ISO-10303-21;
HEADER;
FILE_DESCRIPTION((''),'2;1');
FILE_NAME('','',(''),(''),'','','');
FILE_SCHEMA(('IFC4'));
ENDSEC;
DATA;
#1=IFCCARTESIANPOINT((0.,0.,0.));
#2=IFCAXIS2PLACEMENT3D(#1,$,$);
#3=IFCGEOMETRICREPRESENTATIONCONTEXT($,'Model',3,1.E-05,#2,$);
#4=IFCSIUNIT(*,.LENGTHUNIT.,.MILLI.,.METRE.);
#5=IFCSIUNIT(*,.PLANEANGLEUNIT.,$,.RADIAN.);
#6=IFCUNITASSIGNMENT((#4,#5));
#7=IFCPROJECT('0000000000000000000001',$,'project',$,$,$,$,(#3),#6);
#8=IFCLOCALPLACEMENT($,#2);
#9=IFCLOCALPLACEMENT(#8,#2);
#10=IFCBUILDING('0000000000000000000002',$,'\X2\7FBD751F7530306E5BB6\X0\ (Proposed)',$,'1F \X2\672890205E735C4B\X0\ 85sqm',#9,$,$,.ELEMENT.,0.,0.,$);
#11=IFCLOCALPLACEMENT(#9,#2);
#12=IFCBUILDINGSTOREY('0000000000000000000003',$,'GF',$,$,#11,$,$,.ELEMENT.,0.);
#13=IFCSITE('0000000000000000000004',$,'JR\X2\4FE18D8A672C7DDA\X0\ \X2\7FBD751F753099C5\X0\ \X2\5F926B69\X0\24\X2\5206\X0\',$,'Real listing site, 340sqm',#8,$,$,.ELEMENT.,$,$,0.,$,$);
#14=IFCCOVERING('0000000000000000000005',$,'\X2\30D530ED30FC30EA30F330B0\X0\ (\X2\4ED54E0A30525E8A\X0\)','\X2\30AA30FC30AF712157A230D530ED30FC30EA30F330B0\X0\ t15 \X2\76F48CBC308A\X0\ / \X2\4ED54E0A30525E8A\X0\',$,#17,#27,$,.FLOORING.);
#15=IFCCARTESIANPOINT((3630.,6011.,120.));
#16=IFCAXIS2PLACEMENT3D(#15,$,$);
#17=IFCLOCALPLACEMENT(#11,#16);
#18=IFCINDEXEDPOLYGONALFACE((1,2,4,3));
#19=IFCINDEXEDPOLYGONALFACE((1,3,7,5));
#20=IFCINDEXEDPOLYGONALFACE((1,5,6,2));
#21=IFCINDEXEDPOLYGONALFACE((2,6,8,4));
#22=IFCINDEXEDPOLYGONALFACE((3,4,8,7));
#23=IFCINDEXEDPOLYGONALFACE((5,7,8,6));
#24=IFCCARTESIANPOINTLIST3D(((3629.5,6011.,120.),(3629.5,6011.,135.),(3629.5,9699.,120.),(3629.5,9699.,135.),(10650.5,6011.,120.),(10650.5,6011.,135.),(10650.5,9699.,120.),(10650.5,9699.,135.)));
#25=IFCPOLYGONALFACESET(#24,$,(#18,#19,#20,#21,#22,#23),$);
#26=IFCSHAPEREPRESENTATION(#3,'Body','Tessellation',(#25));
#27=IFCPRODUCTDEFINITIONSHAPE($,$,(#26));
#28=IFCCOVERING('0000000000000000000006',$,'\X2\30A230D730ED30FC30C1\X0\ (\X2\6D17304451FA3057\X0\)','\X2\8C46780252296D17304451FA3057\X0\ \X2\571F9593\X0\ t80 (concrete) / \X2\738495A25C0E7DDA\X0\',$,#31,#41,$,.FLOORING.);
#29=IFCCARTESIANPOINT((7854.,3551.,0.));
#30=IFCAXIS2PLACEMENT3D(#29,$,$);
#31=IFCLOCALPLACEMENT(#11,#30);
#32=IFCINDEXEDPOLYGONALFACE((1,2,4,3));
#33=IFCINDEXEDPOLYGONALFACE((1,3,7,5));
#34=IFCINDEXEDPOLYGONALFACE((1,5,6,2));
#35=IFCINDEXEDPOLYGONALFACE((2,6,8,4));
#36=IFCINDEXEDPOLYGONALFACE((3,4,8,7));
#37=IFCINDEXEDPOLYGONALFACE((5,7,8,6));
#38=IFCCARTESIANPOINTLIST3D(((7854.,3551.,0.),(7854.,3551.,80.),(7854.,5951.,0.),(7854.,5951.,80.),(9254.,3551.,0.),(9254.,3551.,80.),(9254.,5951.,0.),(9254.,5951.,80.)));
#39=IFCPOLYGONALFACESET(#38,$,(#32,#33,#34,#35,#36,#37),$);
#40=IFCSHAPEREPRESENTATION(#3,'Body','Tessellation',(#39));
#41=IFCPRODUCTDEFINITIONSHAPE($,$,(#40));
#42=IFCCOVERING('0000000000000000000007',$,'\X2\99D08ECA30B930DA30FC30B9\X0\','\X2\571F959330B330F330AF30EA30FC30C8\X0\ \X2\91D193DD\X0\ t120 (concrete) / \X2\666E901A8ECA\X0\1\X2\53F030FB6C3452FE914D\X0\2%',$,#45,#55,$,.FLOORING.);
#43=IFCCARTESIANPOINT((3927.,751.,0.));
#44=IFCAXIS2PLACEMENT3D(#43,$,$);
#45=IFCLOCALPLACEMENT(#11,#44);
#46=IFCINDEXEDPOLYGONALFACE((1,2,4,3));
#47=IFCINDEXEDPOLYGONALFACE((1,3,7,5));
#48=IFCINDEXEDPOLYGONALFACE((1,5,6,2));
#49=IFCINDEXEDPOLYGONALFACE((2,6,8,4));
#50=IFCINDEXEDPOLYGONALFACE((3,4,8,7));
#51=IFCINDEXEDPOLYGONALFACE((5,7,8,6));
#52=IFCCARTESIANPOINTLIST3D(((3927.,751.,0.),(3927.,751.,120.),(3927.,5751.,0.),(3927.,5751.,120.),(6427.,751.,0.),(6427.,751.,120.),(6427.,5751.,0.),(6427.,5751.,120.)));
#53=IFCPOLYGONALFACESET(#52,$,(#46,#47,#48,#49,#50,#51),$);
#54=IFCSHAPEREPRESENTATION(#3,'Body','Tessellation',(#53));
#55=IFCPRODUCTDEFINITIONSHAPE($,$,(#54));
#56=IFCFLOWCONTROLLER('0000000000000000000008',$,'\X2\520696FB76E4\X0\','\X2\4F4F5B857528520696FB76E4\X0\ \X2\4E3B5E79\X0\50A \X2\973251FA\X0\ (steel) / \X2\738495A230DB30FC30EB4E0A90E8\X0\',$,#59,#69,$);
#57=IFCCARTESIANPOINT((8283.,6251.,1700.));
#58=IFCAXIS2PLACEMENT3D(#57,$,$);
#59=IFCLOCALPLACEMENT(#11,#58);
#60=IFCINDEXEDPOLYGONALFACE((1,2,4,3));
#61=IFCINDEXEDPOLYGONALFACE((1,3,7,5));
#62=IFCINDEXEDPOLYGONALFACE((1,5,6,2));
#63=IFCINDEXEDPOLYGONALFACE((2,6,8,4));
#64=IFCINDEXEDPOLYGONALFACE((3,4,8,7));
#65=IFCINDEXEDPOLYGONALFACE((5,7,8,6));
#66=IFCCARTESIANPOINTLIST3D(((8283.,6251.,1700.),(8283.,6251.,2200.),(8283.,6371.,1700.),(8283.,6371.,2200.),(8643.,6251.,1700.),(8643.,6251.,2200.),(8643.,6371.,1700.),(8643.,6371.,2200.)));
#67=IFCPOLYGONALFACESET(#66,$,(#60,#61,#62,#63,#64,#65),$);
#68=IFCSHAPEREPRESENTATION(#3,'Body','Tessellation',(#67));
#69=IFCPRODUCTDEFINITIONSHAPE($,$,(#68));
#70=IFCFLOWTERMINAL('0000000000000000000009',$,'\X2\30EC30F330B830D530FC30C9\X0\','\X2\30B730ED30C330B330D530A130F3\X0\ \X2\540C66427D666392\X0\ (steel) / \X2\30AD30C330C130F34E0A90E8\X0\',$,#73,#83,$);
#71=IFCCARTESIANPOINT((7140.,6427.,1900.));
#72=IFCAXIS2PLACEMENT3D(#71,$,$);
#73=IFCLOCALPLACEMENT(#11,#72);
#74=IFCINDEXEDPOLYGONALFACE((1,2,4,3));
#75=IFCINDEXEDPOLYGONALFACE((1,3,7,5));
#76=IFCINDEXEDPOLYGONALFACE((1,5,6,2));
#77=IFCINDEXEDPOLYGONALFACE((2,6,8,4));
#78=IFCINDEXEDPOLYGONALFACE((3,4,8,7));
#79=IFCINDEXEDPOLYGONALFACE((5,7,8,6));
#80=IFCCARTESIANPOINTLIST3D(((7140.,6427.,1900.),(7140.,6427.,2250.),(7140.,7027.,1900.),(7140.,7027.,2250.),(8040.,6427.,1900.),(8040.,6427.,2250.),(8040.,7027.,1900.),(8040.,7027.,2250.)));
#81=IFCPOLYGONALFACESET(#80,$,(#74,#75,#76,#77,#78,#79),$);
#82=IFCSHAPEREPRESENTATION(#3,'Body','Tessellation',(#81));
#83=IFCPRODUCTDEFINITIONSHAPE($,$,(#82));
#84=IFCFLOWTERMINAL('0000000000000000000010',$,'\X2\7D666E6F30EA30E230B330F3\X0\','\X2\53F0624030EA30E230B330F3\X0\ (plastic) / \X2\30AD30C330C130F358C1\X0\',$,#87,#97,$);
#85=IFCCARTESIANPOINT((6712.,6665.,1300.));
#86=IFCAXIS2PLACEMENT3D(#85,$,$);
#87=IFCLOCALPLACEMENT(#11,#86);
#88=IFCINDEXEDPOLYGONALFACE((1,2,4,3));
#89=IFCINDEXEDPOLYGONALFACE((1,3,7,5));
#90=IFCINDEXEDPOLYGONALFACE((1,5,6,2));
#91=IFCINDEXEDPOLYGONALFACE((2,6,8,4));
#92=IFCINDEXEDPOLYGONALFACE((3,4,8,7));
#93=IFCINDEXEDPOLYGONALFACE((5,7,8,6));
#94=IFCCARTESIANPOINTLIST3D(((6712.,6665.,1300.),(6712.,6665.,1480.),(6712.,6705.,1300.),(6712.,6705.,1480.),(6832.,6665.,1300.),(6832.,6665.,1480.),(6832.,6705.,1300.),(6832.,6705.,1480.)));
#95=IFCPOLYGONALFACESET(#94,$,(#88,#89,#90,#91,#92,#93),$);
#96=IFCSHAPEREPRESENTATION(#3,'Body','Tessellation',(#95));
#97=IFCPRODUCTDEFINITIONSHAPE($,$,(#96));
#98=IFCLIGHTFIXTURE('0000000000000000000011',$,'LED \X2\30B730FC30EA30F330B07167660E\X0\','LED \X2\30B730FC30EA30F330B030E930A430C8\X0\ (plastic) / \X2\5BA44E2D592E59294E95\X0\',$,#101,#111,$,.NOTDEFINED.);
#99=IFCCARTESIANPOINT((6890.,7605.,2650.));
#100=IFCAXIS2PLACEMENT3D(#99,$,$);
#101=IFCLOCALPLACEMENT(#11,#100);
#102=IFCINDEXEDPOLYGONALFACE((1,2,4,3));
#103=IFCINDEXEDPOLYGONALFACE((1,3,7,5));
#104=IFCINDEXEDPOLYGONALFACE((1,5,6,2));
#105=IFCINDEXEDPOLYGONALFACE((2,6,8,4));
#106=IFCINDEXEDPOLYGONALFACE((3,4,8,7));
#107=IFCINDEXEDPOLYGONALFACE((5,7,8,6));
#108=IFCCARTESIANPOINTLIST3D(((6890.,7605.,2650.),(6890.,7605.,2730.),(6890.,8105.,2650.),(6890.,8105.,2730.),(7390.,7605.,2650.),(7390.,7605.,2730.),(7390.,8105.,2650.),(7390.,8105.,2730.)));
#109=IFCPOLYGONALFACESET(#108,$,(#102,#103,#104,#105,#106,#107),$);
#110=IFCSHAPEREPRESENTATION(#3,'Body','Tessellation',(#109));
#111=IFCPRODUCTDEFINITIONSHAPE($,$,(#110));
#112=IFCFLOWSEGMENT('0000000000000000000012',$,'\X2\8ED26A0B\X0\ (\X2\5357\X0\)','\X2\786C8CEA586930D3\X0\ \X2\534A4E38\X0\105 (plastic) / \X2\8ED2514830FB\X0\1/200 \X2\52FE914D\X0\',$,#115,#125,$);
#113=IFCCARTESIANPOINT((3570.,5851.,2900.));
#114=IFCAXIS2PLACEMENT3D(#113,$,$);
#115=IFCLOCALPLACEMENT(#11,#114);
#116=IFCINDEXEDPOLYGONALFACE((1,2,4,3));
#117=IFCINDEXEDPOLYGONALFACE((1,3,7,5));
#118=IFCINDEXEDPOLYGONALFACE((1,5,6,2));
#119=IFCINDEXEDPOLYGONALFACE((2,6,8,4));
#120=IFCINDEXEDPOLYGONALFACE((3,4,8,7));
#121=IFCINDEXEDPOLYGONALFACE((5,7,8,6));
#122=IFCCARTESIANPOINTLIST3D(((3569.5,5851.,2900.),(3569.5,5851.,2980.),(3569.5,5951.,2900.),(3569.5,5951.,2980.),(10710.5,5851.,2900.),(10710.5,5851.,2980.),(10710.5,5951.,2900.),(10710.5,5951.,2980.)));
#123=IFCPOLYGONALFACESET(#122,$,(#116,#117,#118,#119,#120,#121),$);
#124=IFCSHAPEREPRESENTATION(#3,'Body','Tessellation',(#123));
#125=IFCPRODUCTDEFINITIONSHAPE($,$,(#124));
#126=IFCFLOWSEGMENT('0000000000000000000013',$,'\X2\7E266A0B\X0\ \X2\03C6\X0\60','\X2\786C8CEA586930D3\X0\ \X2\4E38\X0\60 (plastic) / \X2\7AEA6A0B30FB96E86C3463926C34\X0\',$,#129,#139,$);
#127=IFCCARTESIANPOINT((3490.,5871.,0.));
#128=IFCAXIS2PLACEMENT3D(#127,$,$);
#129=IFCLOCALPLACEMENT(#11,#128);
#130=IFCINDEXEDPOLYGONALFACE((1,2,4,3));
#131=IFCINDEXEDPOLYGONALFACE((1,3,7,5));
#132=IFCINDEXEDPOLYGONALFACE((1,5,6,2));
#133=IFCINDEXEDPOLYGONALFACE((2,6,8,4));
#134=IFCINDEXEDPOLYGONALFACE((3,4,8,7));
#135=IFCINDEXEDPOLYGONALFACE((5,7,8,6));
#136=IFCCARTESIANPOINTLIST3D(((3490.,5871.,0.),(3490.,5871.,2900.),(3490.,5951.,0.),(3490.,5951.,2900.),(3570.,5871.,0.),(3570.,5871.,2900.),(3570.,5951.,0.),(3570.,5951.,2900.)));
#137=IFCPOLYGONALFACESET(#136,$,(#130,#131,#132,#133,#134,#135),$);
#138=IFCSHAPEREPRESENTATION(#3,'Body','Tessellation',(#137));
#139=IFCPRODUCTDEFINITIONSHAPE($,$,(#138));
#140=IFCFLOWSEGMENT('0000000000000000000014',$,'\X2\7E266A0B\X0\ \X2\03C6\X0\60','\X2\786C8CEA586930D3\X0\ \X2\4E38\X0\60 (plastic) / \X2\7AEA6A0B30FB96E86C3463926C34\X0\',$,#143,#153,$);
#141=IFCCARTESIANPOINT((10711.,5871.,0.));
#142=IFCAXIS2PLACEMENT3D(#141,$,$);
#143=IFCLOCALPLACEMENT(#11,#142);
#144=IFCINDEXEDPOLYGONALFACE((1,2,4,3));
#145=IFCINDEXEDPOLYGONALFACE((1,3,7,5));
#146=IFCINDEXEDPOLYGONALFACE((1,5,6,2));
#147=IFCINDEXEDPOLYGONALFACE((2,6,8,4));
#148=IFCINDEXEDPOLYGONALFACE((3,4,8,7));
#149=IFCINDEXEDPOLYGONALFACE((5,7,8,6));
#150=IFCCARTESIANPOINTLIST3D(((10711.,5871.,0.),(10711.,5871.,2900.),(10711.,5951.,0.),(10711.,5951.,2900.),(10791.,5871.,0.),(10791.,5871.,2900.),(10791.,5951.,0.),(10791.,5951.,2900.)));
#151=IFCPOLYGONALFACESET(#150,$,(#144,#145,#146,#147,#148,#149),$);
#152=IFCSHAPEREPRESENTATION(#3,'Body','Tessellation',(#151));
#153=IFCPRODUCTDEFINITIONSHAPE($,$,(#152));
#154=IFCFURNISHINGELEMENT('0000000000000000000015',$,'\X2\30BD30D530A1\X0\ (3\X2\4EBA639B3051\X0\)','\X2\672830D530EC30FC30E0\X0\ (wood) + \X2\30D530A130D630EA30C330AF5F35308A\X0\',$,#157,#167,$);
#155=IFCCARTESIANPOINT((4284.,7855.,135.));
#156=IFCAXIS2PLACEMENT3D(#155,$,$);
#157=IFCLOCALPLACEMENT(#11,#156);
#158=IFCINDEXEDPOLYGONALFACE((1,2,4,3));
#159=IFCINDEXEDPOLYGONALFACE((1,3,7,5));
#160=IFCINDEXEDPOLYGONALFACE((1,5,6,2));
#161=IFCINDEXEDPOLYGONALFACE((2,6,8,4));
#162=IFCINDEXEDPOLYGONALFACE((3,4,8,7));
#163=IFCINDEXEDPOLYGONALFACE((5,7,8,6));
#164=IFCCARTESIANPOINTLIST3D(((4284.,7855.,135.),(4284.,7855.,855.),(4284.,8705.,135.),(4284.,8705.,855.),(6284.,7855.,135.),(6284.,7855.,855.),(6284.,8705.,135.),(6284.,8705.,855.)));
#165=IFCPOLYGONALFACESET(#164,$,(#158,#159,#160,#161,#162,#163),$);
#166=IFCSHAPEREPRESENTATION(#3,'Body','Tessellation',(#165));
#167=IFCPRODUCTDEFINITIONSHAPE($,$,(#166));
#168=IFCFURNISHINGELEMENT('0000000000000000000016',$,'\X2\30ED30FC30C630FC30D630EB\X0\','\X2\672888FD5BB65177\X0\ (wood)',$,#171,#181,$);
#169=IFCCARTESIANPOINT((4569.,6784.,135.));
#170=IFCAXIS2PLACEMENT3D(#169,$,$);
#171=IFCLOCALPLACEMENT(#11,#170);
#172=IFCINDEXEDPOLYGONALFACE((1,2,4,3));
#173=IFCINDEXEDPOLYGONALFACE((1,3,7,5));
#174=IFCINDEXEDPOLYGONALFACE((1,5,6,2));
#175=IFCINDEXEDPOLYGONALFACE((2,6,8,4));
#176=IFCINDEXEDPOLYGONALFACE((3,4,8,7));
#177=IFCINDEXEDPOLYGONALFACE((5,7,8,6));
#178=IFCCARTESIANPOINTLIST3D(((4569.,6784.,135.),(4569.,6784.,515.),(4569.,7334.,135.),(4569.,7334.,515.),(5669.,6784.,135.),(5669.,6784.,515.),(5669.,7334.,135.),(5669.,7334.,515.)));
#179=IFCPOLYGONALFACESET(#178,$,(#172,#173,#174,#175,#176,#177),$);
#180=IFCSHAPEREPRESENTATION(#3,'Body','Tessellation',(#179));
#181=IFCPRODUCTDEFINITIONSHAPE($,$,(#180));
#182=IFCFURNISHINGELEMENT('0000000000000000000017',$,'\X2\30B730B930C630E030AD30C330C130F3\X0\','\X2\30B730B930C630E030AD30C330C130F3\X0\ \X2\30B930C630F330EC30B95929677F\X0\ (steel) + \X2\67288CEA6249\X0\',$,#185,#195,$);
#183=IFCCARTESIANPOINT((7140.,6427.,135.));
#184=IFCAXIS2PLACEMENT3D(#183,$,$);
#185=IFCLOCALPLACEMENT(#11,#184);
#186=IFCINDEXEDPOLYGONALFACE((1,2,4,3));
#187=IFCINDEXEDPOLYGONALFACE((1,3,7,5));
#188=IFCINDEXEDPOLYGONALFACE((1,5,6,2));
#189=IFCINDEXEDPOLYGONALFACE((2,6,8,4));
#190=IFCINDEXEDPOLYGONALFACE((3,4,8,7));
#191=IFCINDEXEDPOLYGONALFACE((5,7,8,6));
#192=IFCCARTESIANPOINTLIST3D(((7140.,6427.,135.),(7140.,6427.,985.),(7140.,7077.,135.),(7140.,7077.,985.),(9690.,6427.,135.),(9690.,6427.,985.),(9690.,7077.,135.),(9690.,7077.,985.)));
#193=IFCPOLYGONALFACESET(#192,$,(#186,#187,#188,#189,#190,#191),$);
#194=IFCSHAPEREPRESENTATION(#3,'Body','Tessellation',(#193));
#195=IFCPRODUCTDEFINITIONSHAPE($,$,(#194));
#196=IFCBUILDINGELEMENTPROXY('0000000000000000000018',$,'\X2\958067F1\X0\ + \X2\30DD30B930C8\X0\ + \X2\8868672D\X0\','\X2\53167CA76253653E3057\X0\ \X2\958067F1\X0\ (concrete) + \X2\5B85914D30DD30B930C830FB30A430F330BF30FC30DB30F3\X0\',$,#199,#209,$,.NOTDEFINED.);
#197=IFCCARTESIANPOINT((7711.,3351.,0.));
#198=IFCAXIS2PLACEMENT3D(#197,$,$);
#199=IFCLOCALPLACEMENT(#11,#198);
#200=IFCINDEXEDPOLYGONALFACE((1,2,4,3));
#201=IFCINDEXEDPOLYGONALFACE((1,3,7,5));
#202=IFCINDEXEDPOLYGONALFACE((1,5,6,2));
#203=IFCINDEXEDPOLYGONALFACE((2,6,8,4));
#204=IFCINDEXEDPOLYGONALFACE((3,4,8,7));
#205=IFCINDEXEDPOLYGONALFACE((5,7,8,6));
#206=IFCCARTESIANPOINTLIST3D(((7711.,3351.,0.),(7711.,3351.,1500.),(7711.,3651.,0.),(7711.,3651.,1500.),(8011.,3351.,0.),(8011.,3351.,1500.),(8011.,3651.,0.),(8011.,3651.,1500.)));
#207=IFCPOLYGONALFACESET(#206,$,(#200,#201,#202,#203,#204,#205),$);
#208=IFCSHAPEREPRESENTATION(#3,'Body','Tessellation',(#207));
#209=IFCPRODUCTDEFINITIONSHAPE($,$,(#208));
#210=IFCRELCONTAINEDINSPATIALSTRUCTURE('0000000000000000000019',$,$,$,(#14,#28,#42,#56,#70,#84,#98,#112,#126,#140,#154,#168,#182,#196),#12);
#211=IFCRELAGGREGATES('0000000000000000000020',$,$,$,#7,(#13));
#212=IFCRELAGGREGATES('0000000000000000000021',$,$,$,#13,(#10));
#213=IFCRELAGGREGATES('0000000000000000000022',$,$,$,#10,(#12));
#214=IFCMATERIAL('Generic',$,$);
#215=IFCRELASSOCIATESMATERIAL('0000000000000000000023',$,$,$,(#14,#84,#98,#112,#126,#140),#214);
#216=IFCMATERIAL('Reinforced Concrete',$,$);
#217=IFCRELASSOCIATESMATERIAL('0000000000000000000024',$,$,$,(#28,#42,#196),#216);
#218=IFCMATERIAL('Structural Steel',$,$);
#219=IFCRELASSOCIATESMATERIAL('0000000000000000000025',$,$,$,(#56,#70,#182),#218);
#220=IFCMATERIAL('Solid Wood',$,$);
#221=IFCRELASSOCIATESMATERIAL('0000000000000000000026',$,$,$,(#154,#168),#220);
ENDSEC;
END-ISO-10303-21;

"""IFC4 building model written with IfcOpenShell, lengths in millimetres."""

from ifc_helpers import new_model, si_unit, frame, frame_2d, origin, place, context, project, spatial, rectangle, extrude, material, element, save


model = new_model("IFC4")

# Units and contexts
model_context = context("Model", 3, precision=1e-05, world=origin())
ifc_project = project(units=[si_unit("LENGTHUNIT", "METRE", prefix="MILLI"), si_unit("PLANEANGLEUNIT", "RADIAN")], contexts=[model_context])

# Site, building, storey
site_placement = place(None, origin())
site = spatial("IfcSite", under=ifc_project, at=site_placement, Name="JR信越本線 羽生田駅 徒歩24分", ObjectType="Real listing site, 340sqm", CompositionType="ELEMENT", RefElevation=0.0)
building_placement = place(site_placement, origin())
building = spatial("IfcBuilding", under=site, at=building_placement, Name="羽生田の家 (Proposed)", ObjectType="1F 木造平屋 85sqm", CompositionType="ELEMENT", ElevationOfRefHeight=0.0, ElevationOfTerrain=0.0)
storey_placement = place(building_placement, origin())
storey = spatial("IfcBuildingStorey", under=building, at=storey_placement, Name="GF", CompositionType="ELEMENT", Elevation=0.0)

# Shared definitions
ifc_material_1 = material(Name="Solid Wood")

# Shared definitions
ifc_material_2 = material(Name="Reinforced Concrete")

# Shared definitions
ifc_material_3 = material(Name="Structural Steel")

# Coverings
ifc_material_4 = material(Name="Generic")
covering_1_placement = place(storey_placement, frame((3630.0, 6011.0, 120.0)))
element("IfcCovering", 1, at=covering_1_placement, inside=storey, material=ifc_material_4, Name="フローリング (仕上げ床)", Description="オーク無垢フローリング t15 直貼り / 仕上げ床", PredefinedType="FLOORING", context=model_context, shape_type="SweptSolid", body=[
    extrude(rectangle(XDim=7021.0, YDim=3688.0, at=frame_2d((3510.0, 1844.0))), frame((3630.0, 6011.0, 120.0)), (0.0, 0.0, 1.0), 15.0),
])
covering_2_placement = place(storey_placement, frame((7854.0, 3551.0, 0.0)))
element("IfcCovering", 2, at=covering_2_placement, inside=storey, material=ifc_material_2, Name="アプローチ (洗い出し)", Description="豆砂利洗い出し 土間 t80 (concrete) / 玄関導線", PredefinedType="FLOORING", context=model_context, shape_type="SweptSolid", body=[
    extrude(rectangle(XDim=1400.0, YDim=2400.0, at=frame_2d((700.0, 1200.0))), frame((7854.0, 3551.0, 0.0)), (0.0, 0.0, 1.0), 80.0),
])
covering_3_placement = place(storey_placement, frame((3927.0, 751.0, 0.0)))
element("IfcCovering", 3, at=covering_3_placement, inside=storey, material=ifc_material_2, Name="駐車スペース", Description="土間コンクリート 金鏝 t120 (concrete) / 普通車1台・水勾配2%", PredefinedType="FLOORING", context=model_context, shape_type="SweptSolid", body=[
    extrude(rectangle(XDim=2500.0, YDim=5000.0, at=frame_2d((1250.0, 2500.0))), frame((3927.0, 751.0, 0.0)), (0.0, 0.0, 1.0), 120.0),
])

# Flow controller
flow_controller_placement = place(storey_placement, frame((8283.0, 6251.0, 1700.0)))
element("IfcFlowController", 4, at=flow_controller_placement, inside=storey, material=ifc_material_3, Name="分電盤", Description="住宅用分電盤 主幹50A 露出 (steel) / 玄関ホール上部", context=model_context, shape_type="SweptSolid", body=[
    extrude(rectangle(XDim=360.0, YDim=120.0, at=frame_2d((180.0, 60.0))), frame((8283.0, 6251.0, 1700.0)), (0.0, 0.0, 1.0), 500.0),
])

# Flow terminals
flow_terminal_1_placement = place(storey_placement, frame((7140.0, 6427.0, 1900.0)))
element("IfcFlowTerminal", 5, at=flow_terminal_1_placement, inside=storey, material=ifc_material_3, Name="レンジフード", Description="シロッコファン 同時給排 (steel) / キッチン上部", context=model_context, shape_type="SweptSolid", body=[
    extrude(rectangle(XDim=900.0, YDim=600.0, at=frame_2d((450.0, 300.0))), frame((7140.0, 6427.0, 1900.0)), (0.0, 0.0, 1.0), 350.0),
])
flow_terminal_2_placement = place(storey_placement, frame((6712.0, 6665.0, 1300.0)))
element("IfcFlowTerminal", 6, at=flow_terminal_2_placement, inside=storey, material=ifc_material_4, Name="給湯リモコン", Description="台所リモコン (plastic) / キッチン壁", context=model_context, shape_type="SweptSolid", body=[
    extrude(rectangle(XDim=120.0, YDim=40.0, at=frame_2d((60.0, 20.0))), frame((6712.0, 6665.0, 1300.0)), (0.0, 0.0, 1.0), 180.0),
])

# Light fixture
light_fixture_placement = place(storey_placement, frame((6890.0, 7605.0, 2650.0)))
element("IfcLightFixture", 7, at=light_fixture_placement, inside=storey, material=ifc_material_4, Name="LED シーリング照明", Description="LED シーリングライト (plastic) / 室中央天井", PredefinedType="NOTDEFINED", context=model_context, shape_type="SweptSolid", body=[
    extrude(rectangle(XDim=500.0, YDim=500.0, at=frame_2d((250.0, 250.0))), frame((6890.0, 7605.0, 2650.0)), (0.0, 0.0, 1.0), 80.0),
])

# Flow segments
flow_segment_1_placement = place(storey_placement, frame((3570.0, 5851.0, 2900.0)))
element("IfcFlowSegment", 8, at=flow_segment_1_placement, inside=storey, material=ifc_material_4, Name="軒樋 (南)", Description="硬質塩ビ 半丸105 (plastic) / 軒先・1/200 勾配", context=model_context, shape_type="SweptSolid", body=[
    extrude(rectangle(XDim=7141.0, YDim=100.0, at=frame_2d((3570.0, 50.0))), frame((3570.0, 5851.0, 2900.0)), (0.0, 0.0, 1.0), 80.0),
])
flow_segment_2_placement = place(storey_placement, frame((3490.0, 5871.0, 0.0)))
element("IfcFlowSegment", 9, at=flow_segment_2_placement, inside=storey, material=ifc_material_4, Name="縦樋 φ60", Description="硬質塩ビ 丸60 (plastic) / 竪樋・雨水排水", context=model_context, shape_type="SweptSolid", body=[
    extrude(rectangle(XDim=80.0, YDim=80.0, at=frame_2d((40.0, 40.0))), frame((3490.0, 5871.0, 0.0)), (0.0, 0.0, 1.0), 2900.0),
])
flow_segment_3_placement = place(storey_placement, frame((10711.0, 5871.0, 0.0)))
element("IfcFlowSegment", 10, at=flow_segment_3_placement, inside=storey, material=ifc_material_4, Name="縦樋 φ60", Description="硬質塩ビ 丸60 (plastic) / 竪樋・雨水排水", context=model_context, shape_type="SweptSolid", body=[
    extrude(rectangle(XDim=80.0, YDim=80.0, at=frame_2d((40.0, 40.0))), frame((10711.0, 5871.0, 0.0)), (0.0, 0.0, 1.0), 2900.0),
])

# Furnishing elements
furnishing_1_placement = place(storey_placement, frame((4284.0, 7855.0, 135.0)))
element("IfcFurnishingElement", 11, at=furnishing_1_placement, inside=storey, material=ifc_material_1, Name="ソファ (3人掛け)", Description="木フレーム (wood) + ファブリック張り", context=model_context, shape_type="SweptSolid", body=[
    extrude(rectangle(XDim=2000.0, YDim=850.0, at=frame_2d((1000.0, 425.0))), frame((4284.0, 7855.0, 135.0)), (0.0, 0.0, 1.0), 720.0),
])
furnishing_2_placement = place(storey_placement, frame((4569.0, 6784.0, 135.0)))
element("IfcFurnishingElement", 12, at=furnishing_2_placement, inside=storey, material=ifc_material_1, Name="ローテーブル", Description="木製家具 (wood)", context=model_context, shape_type="SweptSolid", body=[
    extrude(rectangle(XDim=1100.0, YDim=550.0, at=frame_2d((550.0, 275.0))), frame((4569.0, 6784.0, 135.0)), (0.0, 0.0, 1.0), 380.0),
])
furnishing_3_placement = place(storey_placement, frame((7140.0, 6427.0, 135.0)))
element("IfcFurnishingElement", 13, at=furnishing_3_placement, inside=storey, material=ifc_material_3, Name="システムキッチン", Description="システムキッチン ステンレス天板 (steel) + 木質扉", context=model_context, shape_type="SweptSolid", body=[
    extrude(rectangle(XDim=2550.0, YDim=650.0, at=frame_2d((1275.0, 325.0))), frame((7140.0, 6427.0, 135.0)), (0.0, 0.0, 1.0), 850.0),
])

# Building element proxy
proxy_placement = place(storey_placement, frame((7711.0, 3351.0, 0.0)))
element("IfcBuildingElementProxy", 14, at=proxy_placement, inside=storey, material=ifc_material_2, Name="門柱 + ポスト + 表札", Description="化粧打放し 門柱 (concrete) + 宅配ポスト・インターホン", PredefinedType="NOTDEFINED", context=model_context, shape_type="SweptSolid", body=[
    extrude(rectangle(XDim=300.0, YDim=300.0, at=frame_2d((150.0, 150.0))), frame((7711.0, 3351.0, 0.0)), (0.0, 0.0, 1.0), 1500.0),
])

save(model, "model.ifc")
